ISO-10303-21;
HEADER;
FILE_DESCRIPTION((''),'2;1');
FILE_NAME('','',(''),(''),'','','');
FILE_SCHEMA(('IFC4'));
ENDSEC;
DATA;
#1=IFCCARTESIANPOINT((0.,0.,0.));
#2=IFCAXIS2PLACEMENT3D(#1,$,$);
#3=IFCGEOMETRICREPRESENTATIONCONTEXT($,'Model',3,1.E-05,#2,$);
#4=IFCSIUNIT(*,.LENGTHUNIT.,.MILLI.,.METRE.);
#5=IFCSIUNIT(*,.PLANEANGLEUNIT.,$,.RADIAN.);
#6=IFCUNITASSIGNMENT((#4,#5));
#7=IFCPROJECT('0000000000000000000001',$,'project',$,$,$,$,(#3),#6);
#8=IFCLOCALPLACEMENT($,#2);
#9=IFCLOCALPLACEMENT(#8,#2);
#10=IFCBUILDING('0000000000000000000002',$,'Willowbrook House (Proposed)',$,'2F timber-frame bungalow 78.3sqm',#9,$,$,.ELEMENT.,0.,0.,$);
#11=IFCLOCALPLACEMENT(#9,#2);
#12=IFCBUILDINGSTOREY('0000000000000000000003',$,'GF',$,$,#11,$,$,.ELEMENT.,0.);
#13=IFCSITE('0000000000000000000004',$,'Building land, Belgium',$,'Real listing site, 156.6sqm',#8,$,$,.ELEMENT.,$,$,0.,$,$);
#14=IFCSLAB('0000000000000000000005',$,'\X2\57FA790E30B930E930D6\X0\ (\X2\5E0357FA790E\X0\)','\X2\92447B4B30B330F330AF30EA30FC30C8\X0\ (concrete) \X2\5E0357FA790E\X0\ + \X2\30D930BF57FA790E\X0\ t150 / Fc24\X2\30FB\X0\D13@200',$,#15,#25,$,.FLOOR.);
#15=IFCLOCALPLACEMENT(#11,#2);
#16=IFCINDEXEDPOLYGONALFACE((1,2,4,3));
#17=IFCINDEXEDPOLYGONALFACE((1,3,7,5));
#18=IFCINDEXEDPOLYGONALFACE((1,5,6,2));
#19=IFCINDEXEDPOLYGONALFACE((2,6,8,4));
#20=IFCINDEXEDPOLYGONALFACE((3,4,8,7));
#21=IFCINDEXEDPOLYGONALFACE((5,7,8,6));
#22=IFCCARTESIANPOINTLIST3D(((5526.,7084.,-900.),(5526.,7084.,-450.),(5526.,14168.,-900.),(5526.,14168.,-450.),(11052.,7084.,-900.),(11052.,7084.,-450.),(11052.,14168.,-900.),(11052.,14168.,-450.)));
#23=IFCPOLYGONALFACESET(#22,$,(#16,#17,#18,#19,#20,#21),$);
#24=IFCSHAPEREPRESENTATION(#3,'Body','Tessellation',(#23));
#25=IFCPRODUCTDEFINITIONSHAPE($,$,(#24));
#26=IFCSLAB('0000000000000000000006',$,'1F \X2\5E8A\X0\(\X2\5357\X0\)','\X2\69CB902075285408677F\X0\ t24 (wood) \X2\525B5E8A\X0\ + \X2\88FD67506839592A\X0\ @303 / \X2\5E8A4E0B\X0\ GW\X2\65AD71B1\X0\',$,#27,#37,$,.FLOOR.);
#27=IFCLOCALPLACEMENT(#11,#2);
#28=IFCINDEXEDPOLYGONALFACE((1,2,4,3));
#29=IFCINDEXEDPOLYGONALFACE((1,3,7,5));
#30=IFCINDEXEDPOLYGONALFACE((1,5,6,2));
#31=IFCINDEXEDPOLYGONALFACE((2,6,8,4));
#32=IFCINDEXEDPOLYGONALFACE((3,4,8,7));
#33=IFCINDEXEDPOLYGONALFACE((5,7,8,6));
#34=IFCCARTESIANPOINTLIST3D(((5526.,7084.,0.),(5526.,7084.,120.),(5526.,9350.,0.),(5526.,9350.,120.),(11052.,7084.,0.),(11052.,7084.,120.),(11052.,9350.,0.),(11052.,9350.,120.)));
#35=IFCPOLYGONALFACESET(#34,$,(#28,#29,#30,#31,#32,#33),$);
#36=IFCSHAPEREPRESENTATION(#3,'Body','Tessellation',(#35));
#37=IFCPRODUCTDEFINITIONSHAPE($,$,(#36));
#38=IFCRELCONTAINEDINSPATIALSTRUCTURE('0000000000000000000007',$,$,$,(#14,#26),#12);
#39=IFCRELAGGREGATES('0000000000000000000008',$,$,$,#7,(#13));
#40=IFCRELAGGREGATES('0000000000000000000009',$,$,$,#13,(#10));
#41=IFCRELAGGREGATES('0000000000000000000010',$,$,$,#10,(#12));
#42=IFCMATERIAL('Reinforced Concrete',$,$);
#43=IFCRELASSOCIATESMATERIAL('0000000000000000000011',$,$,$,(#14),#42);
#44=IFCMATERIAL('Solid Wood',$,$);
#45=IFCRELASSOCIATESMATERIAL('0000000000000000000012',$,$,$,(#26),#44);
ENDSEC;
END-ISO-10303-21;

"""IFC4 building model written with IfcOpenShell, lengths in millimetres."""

from ifc_helpers import new_model, si_unit, frame, frame_2d, origin, place, context, project, spatial, rectangle, extrude, material, element, save


model = new_model("IFC4")

# Units and contexts
model_context = context("Model", 3, precision=1e-05, world=origin())
ifc_project = project(units=[si_unit("LENGTHUNIT", "METRE", prefix="MILLI"), si_unit("PLANEANGLEUNIT", "RADIAN")], contexts=[model_context])

# Site, building, storey
site_placement = place(None, origin())
site = spatial("IfcSite", under=ifc_project, at=site_placement, Name="Building land, Belgium", ObjectType="Real listing site, 156.6sqm", CompositionType="ELEMENT", RefElevation=0.0)
building_placement = place(site_placement, origin())
building = spatial("IfcBuilding", under=site, at=building_placement, Name="Willowbrook House (Proposed)", ObjectType="2F timber-frame bungalow 78.3sqm", CompositionType="ELEMENT", ElevationOfRefHeight=0.0, ElevationOfTerrain=0.0)
storey_placement = place(building_placement, origin())
storey = spatial("IfcBuildingStorey", under=building, at=storey_placement, Name="GF", CompositionType="ELEMENT", Elevation=0.0)

# Slabs
ifc_material_1 = material(Name="Reinforced Concrete")
slab_1_placement = place(storey_placement, frame((2763.0, 3542.0, -450.0)))
element("IfcSlab", 1, at=slab_1_placement, inside=storey, material=ifc_material_1, Name="基礎スラブ (布基礎)", Description="鉄筋コンクリート (concrete) 布基礎 + ベタ基礎 t150 / Fc24・D13@200", PredefinedType="FLOOR", context=model_context, shape_type="SweptSolid", body=[
    extrude(rectangle(XDim=5526.0, YDim=7084.0, at=frame_2d((2763.0, 3542.0))), frame((2763.0, 3542.0, -450.0)), (0.0, 0.0, 1.0), 450.0),
])
ifc_material_2 = material(Name="Solid Wood")
slab_2_placement = place(storey_placement, frame((2763.0, 3542.0, 0.0)))
element("IfcSlab", 2, at=slab_2_placement, inside=storey, material=ifc_material_2, Name="1F 床(南)", Description="構造用合板 t24 (wood) 剛床 + 製材根太 @303 / 床下 GW断熱", PredefinedType="FLOOR", context=model_context, shape_type="SweptSolid", body=[
    extrude(rectangle(XDim=5526.0, YDim=2266.0, at=frame_2d((2763.0, 1133.0))), frame((2763.0, 3542.0, 0.0)), (0.0, 0.0, 1.0), 120.0),
])

save(model, "model.ifc")
